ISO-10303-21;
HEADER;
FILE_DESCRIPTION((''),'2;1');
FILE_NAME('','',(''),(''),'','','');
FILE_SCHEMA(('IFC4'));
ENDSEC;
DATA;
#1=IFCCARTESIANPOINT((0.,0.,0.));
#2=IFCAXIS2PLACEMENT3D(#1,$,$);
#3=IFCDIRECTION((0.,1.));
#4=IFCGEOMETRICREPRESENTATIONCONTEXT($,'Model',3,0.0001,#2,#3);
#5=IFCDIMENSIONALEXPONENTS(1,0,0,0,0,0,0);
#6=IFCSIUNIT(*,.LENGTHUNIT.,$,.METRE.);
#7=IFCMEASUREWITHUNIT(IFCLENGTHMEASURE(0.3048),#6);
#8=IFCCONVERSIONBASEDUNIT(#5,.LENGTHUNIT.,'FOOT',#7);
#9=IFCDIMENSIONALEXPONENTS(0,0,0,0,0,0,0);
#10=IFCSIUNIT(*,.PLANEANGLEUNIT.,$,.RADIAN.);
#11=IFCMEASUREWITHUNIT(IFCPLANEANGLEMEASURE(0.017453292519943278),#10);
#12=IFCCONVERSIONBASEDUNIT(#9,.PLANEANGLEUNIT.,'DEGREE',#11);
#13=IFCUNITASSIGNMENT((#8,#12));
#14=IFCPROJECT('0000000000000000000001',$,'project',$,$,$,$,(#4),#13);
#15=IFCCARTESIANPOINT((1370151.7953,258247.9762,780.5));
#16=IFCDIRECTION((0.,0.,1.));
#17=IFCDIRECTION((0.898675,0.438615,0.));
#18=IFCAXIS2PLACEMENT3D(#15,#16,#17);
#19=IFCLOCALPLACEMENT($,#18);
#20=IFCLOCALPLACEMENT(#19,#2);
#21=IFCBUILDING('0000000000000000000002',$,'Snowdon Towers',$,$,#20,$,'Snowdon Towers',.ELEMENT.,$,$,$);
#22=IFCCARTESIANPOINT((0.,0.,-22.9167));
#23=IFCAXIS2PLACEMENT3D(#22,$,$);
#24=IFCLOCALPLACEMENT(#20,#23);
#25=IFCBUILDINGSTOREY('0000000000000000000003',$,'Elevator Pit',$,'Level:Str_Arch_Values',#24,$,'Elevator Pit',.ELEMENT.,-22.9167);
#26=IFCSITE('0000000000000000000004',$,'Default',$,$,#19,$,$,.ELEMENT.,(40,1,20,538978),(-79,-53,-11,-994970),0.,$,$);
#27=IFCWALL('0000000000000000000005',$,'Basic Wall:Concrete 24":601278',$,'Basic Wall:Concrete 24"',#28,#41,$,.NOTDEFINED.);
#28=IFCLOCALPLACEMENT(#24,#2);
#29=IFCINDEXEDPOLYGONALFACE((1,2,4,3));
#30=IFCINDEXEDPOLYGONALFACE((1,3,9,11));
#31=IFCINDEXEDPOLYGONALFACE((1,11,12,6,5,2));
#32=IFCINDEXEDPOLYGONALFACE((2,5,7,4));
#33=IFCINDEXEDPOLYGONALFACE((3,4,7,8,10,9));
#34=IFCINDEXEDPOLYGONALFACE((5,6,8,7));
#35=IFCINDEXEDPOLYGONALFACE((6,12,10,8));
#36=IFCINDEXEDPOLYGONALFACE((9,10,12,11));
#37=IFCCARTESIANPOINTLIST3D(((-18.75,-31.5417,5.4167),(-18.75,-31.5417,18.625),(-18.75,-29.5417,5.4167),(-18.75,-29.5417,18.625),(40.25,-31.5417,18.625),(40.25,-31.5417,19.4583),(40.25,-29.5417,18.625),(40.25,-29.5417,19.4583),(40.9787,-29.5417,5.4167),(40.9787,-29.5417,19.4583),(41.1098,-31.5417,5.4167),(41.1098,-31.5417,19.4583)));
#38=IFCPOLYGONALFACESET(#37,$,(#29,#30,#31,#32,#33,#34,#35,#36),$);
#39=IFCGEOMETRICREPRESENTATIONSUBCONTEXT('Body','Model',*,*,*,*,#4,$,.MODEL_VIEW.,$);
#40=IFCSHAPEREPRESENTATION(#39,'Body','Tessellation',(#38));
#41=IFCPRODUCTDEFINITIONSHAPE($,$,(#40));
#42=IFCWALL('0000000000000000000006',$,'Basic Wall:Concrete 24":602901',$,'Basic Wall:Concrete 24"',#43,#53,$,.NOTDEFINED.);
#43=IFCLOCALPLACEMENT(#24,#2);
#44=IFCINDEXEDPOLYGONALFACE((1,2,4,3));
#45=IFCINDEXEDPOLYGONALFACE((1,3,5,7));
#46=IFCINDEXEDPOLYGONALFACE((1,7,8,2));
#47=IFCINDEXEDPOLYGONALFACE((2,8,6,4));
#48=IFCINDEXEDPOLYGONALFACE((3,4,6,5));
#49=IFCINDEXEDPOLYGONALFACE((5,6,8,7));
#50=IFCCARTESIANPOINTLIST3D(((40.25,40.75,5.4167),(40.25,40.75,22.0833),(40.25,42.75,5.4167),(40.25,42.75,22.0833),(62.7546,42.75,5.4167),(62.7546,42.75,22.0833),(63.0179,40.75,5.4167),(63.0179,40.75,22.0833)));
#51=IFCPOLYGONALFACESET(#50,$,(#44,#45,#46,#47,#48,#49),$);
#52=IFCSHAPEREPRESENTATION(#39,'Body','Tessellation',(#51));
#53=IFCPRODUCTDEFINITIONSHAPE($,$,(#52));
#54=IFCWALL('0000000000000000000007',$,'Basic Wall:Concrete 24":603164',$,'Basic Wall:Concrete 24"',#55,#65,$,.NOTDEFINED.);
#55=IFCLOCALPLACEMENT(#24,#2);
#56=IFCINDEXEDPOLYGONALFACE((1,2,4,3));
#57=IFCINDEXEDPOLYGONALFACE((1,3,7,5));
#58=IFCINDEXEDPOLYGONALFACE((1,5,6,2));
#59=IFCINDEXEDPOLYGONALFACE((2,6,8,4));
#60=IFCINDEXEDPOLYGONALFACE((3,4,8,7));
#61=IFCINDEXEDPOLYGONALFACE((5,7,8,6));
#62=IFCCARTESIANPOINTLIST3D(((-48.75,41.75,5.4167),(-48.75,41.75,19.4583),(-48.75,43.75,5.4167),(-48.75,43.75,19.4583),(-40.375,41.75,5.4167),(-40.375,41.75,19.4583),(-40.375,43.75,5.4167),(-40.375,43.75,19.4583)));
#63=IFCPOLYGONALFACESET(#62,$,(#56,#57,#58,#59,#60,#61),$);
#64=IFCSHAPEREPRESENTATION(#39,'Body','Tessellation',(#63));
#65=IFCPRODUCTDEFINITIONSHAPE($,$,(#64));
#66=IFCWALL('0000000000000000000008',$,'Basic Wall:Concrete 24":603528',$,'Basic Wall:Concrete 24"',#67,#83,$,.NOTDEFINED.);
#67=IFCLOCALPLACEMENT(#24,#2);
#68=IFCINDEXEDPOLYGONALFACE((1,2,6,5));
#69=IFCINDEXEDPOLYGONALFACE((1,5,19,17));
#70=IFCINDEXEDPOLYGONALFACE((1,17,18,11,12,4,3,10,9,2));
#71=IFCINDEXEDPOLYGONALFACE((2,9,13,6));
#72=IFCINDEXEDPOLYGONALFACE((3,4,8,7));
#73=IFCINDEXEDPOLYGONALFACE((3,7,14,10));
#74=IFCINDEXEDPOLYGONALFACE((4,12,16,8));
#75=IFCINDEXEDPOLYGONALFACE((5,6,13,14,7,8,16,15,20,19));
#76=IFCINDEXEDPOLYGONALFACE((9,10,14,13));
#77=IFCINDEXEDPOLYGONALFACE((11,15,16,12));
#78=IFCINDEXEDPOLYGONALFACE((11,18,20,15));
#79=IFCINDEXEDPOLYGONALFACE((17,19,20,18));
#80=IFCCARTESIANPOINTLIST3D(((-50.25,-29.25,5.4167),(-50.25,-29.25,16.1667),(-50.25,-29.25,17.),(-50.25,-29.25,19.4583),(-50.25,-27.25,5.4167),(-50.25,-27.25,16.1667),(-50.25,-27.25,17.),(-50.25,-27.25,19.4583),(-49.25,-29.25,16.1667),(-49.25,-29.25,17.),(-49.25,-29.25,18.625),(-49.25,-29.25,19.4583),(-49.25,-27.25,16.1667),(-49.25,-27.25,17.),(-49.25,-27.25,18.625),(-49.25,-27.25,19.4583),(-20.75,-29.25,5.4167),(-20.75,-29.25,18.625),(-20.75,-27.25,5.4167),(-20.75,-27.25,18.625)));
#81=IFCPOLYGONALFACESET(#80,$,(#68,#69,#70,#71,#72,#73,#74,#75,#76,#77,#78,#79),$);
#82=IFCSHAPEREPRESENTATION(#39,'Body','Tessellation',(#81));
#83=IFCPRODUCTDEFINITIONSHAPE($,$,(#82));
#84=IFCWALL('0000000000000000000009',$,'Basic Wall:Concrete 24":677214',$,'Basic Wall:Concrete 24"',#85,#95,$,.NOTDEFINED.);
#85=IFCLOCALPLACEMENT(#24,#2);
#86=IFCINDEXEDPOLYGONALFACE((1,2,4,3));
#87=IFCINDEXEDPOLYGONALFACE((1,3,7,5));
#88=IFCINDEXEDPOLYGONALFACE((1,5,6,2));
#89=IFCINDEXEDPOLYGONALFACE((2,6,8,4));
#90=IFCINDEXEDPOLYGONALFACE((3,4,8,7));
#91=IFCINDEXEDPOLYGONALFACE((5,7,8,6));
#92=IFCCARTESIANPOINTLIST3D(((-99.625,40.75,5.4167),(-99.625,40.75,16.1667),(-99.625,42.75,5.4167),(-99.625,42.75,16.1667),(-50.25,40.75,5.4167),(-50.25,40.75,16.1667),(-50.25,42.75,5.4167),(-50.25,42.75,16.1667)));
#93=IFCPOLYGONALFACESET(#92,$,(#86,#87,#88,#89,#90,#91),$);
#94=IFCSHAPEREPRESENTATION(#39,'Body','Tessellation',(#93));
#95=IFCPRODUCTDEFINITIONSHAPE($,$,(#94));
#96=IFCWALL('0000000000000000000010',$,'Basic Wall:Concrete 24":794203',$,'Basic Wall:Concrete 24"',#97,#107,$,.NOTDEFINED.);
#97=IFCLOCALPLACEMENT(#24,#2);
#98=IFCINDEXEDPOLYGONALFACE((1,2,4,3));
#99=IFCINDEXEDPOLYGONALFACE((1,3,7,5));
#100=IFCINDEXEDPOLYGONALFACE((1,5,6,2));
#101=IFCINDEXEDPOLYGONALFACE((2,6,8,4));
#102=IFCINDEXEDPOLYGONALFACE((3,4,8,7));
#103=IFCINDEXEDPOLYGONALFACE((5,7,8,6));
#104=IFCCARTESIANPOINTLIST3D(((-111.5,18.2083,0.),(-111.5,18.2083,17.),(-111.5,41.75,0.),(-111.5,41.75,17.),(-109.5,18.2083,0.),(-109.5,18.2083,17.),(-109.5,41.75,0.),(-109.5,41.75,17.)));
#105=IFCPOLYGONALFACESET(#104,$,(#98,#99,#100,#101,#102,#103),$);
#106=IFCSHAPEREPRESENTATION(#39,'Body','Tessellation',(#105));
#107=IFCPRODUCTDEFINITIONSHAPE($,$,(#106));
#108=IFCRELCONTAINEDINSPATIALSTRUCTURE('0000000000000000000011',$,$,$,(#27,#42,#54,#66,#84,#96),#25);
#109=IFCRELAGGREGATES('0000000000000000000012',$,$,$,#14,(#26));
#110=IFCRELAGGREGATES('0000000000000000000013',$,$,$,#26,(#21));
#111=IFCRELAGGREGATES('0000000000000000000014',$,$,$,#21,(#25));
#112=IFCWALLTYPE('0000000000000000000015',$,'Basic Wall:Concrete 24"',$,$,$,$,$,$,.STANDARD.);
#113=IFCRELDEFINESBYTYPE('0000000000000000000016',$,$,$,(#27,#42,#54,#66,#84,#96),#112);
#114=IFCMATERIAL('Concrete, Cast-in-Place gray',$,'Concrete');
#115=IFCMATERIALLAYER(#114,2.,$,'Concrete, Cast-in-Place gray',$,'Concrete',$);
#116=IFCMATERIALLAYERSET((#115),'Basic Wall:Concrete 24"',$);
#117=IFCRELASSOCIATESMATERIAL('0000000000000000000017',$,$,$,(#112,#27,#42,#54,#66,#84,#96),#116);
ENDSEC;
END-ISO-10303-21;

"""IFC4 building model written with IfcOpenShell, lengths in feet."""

from ifc_helpers import new_model, entity, si_unit, converted_unit, direction, frame, frame_2d, origin, place, context, subcontext, project, spatial, polyline, rectangle, outline, extrude, clip, bounded_halfspace, material, layer, layer_set, layer_usage, type_object, element, save


model = new_model("IFC4")

# Units and contexts
model_context = context("Model", 3, precision=0.0001, world=origin(), true_north=direction((0.0, 1.0)))
body_context = subcontext(model_context, "Body", "Model", "MODEL_VIEW")
ifc_project = project(units=[converted_unit("LENGTHUNIT", "FOOT", entity("IfcLengthMeasure", 0.3048), si_unit("LENGTHUNIT", "METRE"), dimensions=[1, 0, 0, 0, 0, 0, 0]), converted_unit("PLANEANGLEUNIT", "DEGREE", entity("IfcPlaneAngleMeasure", 0.017453292519943278), si_unit("PLANEANGLEUNIT", "RADIAN"), dimensions=[0, 0, 0, 0, 0, 0, 0])], contexts=[model_context])

# Site, building, storey
site_placement = place(None, frame((1370151.7953, 258247.9762, 780.5), z_axis=(0.0, 0.0, 1.0), x_axis=(0.898675, 0.438615, 0.0)))
site = spatial("IfcSite", under=ifc_project, at=site_placement, Name="Default", CompositionType="ELEMENT", RefLatitude=(40, 1, 20, 538978), RefLongitude=(-79, -53, -11, -994970), RefElevation=0.0)
building_placement = place(site_placement, origin())
building = spatial("IfcBuilding", under=site, at=building_placement, Name="Snowdon Towers", LongName="Snowdon Towers", CompositionType="ELEMENT")
storey_placement = place(building_placement, frame((0.0, 0.0, -22.9167)))
storey = spatial("IfcBuildingStorey", under=building, at=storey_placement, Name="Elevator Pit", ObjectType="Level:Str_Arch_Values", LongName="Elevator Pit", CompositionType="ELEMENT", Elevation=-22.9167)

# Shared definitions
ifc_material = material(Name="Concrete, Cast-in-Place gray", Category="Concrete")

# Shared definitions
ifc_layer_1 = layer(ifc_material, 2.0, Name="Concrete, Cast-in-Place gray", Category="Concrete")
ifc_layer_set_1 = layer_set([ifc_layer_1], Name="Basic Wall:Concrete 24\"")
wall_type_1 = type_object("IfcWallType", Name="Basic Wall:Concrete 24\"", PredefinedType="STANDARD", material=ifc_layer_set_1)

# Walls
ifc_layer_usage_1 = layer_usage(ifc_layer_set_1, "AXIS2", "NEGATIVE", 1.0)
wall_1_placement = place(storey_placement, frame((-18.75, -30.5417, 5.4167)))
element("IfcWall", 1, at=wall_1_placement, inside=storey, type_object=wall_type_1, material=ifc_layer_usage_1, Name="Basic Wall:Concrete 24\":601278", ObjectType="Basic Wall:Concrete 24\"", PredefinedType="NOTDEFINED", context=body_context, shape_type="Clipping", body=[
    clip(clip(extrude(outline(polyline([(59.8598, -1.0), (59.7287, 1.0), (59.0, 1.0), (0.0, 1.0), (0.0, -1.0), (59.8598, -1.0)])), origin(), (0.0, 0.0, 1.0), 14.0417), bounded_halfspace(frame((59.0, -1.0, 13.2083), z_axis=(0.0, 0.0, -1.0), x_axis=(-1.0, 0.0, 0.0)), True, frame((59.0, -1.0, 13.2083), z_axis=(0.0, 0.0, -1.0), x_axis=(-1.0, 0.0, 0.0)), polyline([(0.0, 0.0), (59.0, 0.0), (59.0, 2.0), (37.6667, 2.0), (35.6667, 2.0), (17.3333, 2.0), (15.3333, 2.0), (0.0, 2.0), (0.0, 0.0)]))), bounded_halfspace(frame((59.0, 1.0, 13.2083), z_axis=(1.0, 0.0, 0.0), x_axis=(0.0, 0.0, 1.0)), True, frame((59.0, 1.0, 13.2083), z_axis=(1.0, 0.0, 0.0), x_axis=(0.0, 0.0, 1.0)), polyline([(0.0, 0.0), (0.8333, 0.0), (0.8333, 2.0), (0.0, 2.0), (0.0, 0.0)]))),
])
ifc_layer_usage_2 = layer_usage(ifc_layer_set_1, "AXIS2", "NEGATIVE", 1.0)
wall_2_placement = place(storey_placement, frame((40.25, 41.75, 5.4167)))
element("IfcWall", 2, at=wall_2_placement, inside=storey, type_object=wall_type_1, material=ifc_layer_usage_2, Name="Basic Wall:Concrete 24\":602901", ObjectType="Basic Wall:Concrete 24\"", PredefinedType="NOTDEFINED", context=body_context, shape_type="Clipping", body=[
    clip(extrude(outline(polyline([(22.7679, -1.0), (22.5046, 1.0), (0.0, 1.0), (0.0, -1.0), (20.7507, -1.0), (22.7679, -1.0)])), origin(), (0.0, 0.0, 1.0), 16.6667), bounded_halfspace(frame((0.0, -1.0, 16.6667), z_axis=(0.0, 0.0, -1.0), x_axis=(-1.0, 0.0, 0.0)), True, frame((0.0, -1.0, 16.6667), z_axis=(0.0, 0.0, -1.0), x_axis=(-1.0, 0.0, 0.0)), polyline([(0.0, 0.0), (0.0, 2.0), (-22.5046, 2.0), (-22.7679, 0.0), (-20.7507, 0.0), (-2.0, 0.0), (0.0, 0.0)]))),
])
ifc_layer_usage_3 = layer_usage(ifc_layer_set_1, "AXIS2", "NEGATIVE", 1.0)
wall_3_placement = place(storey_placement, frame((-48.75, 42.75, 5.4167)))
element("IfcWall", 3, at=wall_3_placement, inside=storey, type_object=wall_type_1, material=ifc_layer_usage_3, Name="Basic Wall:Concrete 24\":603164", ObjectType="Basic Wall:Concrete 24\"", PredefinedType="NOTDEFINED", context=body_context, shape_type="SweptSolid", body=[
    extrude(rectangle(XDim=8.375, YDim=2.0, at=frame_2d((4.1875, 0.0), x_axis=(-1.0, 0.0))), origin(), (0.0, 0.0, 1.0), 14.0417),
])
ifc_layer_usage_4 = layer_usage(ifc_layer_set_1, "AXIS2", "POSITIVE", -1.0)
wall_4_placement = place(storey_placement, frame((-50.25, -28.25, 5.4167)))
element("IfcWall", 4, at=wall_4_placement, inside=storey, type_object=wall_type_1, material=ifc_layer_usage_4, Name="Basic Wall:Concrete 24\":603528", ObjectType="Basic Wall:Concrete 24\"", PredefinedType="NOTDEFINED", context=body_context, shape_type="Clipping", body=[
    clip(clip(clip(extrude(rectangle(XDim=29.5, YDim=2.0, at=frame_2d((14.75, 0.0), x_axis=(-1.0, 0.0))), origin(), (0.0, 0.0, 1.0), 14.0417), bounded_halfspace(frame((1.0, 1.0, 13.2083), z_axis=(0.0, 0.0, -1.0), x_axis=(-1.0, 0.0, 0.0)), True, frame((1.0, 1.0, 13.2083), z_axis=(0.0, 0.0, -1.0), x_axis=(-1.0, 0.0, 0.0)), polyline([(0.0, 0.0), (-1.0, 0.0), (-28.5, 0.0), (-28.5, -2.0), (0.0, -2.0), (0.0, 0.0)]))), bounded_halfspace(frame((1.0, -1.0, 13.2083), z_axis=(-1.0, 0.0, 0.0), x_axis=(0.0, 0.0, 1.0)), True, frame((1.0, -1.0, 13.2083), z_axis=(-1.0, 0.0, 0.0), x_axis=(0.0, 0.0, 1.0)), polyline([(0.0, 0.0), (0.8333, 0.0), (0.8333, 2.0), (0.0, 2.0), (0.0, 0.0)]))), bounded_halfspace(frame((1.0, 1.0, 10.75), z_axis=(1.0, 0.0, 0.0), x_axis=(0.0, 0.0, 1.0)), True, frame((1.0, 1.0, 10.75), z_axis=(1.0, 0.0, 0.0), x_axis=(0.0, 0.0, 1.0)), polyline([(0.0, 0.0), (0.8333, 0.0), (0.8333, 2.0), (0.0, 2.0), (0.0, 0.0)]))),
])
ifc_layer_usage_5 = layer_usage(ifc_layer_set_1, "AXIS2", "NEGATIVE", 1.0)
wall_5_placement = place(storey_placement, frame((-99.625, 41.75, 5.4167)))
element("IfcWall", 5, at=wall_5_placement, inside=storey, type_object=wall_type_1, material=ifc_layer_usage_5, Name="Basic Wall:Concrete 24\":677214", ObjectType="Basic Wall:Concrete 24\"", PredefinedType="NOTDEFINED", context=body_context, shape_type="Clipping", body=[
    clip(extrude(rectangle(XDim=49.375, YDim=2.0, at=frame_2d((24.6875, 0.0), x_axis=(-1.0, 0.0))), origin(), (0.0, 0.0, 1.0), 10.75), bounded_halfspace(frame((0.0, -1.0, 10.75), z_axis=(0.0, 0.0, -1.0), x_axis=(1.0, 0.0, 0.0)), True, frame((0.0, -1.0, 10.75), z_axis=(0.0, 0.0, -1.0), x_axis=(1.0, 0.0, 0.0)), polyline([(0.0, 0.0), (0.0, -2.0), (49.375, -2.0), (49.375, 0.0), (30.375, 0.0), (28.875, 0.0), (0.0, 0.0)]))),
])
ifc_layer_usage_6 = layer_usage(ifc_layer_set_1, "AXIS2", "NEGATIVE", 1.0)
wall_6_placement = place(storey_placement, frame((-110.5, 18.2083, 0.0), z_axis=(0.0, 0.0, 1.0), x_axis=(0.0, 1.0, 0.0)))
element("IfcWall", 6, at=wall_6_placement, inside=storey, type_object=wall_type_1, material=ifc_layer_usage_6, Name="Basic Wall:Concrete 24\":794203", ObjectType="Basic Wall:Concrete 24\"", PredefinedType="NOTDEFINED", context=body_context, shape_type="SweptSolid", body=[
    extrude(rectangle(XDim=23.5417, YDim=2.0, at=frame_2d((11.7708, 0.0), x_axis=(-1.0, 0.0))), origin(), (0.0, 0.0, 1.0), 17.0),
])

save(model, "model.ifc")
